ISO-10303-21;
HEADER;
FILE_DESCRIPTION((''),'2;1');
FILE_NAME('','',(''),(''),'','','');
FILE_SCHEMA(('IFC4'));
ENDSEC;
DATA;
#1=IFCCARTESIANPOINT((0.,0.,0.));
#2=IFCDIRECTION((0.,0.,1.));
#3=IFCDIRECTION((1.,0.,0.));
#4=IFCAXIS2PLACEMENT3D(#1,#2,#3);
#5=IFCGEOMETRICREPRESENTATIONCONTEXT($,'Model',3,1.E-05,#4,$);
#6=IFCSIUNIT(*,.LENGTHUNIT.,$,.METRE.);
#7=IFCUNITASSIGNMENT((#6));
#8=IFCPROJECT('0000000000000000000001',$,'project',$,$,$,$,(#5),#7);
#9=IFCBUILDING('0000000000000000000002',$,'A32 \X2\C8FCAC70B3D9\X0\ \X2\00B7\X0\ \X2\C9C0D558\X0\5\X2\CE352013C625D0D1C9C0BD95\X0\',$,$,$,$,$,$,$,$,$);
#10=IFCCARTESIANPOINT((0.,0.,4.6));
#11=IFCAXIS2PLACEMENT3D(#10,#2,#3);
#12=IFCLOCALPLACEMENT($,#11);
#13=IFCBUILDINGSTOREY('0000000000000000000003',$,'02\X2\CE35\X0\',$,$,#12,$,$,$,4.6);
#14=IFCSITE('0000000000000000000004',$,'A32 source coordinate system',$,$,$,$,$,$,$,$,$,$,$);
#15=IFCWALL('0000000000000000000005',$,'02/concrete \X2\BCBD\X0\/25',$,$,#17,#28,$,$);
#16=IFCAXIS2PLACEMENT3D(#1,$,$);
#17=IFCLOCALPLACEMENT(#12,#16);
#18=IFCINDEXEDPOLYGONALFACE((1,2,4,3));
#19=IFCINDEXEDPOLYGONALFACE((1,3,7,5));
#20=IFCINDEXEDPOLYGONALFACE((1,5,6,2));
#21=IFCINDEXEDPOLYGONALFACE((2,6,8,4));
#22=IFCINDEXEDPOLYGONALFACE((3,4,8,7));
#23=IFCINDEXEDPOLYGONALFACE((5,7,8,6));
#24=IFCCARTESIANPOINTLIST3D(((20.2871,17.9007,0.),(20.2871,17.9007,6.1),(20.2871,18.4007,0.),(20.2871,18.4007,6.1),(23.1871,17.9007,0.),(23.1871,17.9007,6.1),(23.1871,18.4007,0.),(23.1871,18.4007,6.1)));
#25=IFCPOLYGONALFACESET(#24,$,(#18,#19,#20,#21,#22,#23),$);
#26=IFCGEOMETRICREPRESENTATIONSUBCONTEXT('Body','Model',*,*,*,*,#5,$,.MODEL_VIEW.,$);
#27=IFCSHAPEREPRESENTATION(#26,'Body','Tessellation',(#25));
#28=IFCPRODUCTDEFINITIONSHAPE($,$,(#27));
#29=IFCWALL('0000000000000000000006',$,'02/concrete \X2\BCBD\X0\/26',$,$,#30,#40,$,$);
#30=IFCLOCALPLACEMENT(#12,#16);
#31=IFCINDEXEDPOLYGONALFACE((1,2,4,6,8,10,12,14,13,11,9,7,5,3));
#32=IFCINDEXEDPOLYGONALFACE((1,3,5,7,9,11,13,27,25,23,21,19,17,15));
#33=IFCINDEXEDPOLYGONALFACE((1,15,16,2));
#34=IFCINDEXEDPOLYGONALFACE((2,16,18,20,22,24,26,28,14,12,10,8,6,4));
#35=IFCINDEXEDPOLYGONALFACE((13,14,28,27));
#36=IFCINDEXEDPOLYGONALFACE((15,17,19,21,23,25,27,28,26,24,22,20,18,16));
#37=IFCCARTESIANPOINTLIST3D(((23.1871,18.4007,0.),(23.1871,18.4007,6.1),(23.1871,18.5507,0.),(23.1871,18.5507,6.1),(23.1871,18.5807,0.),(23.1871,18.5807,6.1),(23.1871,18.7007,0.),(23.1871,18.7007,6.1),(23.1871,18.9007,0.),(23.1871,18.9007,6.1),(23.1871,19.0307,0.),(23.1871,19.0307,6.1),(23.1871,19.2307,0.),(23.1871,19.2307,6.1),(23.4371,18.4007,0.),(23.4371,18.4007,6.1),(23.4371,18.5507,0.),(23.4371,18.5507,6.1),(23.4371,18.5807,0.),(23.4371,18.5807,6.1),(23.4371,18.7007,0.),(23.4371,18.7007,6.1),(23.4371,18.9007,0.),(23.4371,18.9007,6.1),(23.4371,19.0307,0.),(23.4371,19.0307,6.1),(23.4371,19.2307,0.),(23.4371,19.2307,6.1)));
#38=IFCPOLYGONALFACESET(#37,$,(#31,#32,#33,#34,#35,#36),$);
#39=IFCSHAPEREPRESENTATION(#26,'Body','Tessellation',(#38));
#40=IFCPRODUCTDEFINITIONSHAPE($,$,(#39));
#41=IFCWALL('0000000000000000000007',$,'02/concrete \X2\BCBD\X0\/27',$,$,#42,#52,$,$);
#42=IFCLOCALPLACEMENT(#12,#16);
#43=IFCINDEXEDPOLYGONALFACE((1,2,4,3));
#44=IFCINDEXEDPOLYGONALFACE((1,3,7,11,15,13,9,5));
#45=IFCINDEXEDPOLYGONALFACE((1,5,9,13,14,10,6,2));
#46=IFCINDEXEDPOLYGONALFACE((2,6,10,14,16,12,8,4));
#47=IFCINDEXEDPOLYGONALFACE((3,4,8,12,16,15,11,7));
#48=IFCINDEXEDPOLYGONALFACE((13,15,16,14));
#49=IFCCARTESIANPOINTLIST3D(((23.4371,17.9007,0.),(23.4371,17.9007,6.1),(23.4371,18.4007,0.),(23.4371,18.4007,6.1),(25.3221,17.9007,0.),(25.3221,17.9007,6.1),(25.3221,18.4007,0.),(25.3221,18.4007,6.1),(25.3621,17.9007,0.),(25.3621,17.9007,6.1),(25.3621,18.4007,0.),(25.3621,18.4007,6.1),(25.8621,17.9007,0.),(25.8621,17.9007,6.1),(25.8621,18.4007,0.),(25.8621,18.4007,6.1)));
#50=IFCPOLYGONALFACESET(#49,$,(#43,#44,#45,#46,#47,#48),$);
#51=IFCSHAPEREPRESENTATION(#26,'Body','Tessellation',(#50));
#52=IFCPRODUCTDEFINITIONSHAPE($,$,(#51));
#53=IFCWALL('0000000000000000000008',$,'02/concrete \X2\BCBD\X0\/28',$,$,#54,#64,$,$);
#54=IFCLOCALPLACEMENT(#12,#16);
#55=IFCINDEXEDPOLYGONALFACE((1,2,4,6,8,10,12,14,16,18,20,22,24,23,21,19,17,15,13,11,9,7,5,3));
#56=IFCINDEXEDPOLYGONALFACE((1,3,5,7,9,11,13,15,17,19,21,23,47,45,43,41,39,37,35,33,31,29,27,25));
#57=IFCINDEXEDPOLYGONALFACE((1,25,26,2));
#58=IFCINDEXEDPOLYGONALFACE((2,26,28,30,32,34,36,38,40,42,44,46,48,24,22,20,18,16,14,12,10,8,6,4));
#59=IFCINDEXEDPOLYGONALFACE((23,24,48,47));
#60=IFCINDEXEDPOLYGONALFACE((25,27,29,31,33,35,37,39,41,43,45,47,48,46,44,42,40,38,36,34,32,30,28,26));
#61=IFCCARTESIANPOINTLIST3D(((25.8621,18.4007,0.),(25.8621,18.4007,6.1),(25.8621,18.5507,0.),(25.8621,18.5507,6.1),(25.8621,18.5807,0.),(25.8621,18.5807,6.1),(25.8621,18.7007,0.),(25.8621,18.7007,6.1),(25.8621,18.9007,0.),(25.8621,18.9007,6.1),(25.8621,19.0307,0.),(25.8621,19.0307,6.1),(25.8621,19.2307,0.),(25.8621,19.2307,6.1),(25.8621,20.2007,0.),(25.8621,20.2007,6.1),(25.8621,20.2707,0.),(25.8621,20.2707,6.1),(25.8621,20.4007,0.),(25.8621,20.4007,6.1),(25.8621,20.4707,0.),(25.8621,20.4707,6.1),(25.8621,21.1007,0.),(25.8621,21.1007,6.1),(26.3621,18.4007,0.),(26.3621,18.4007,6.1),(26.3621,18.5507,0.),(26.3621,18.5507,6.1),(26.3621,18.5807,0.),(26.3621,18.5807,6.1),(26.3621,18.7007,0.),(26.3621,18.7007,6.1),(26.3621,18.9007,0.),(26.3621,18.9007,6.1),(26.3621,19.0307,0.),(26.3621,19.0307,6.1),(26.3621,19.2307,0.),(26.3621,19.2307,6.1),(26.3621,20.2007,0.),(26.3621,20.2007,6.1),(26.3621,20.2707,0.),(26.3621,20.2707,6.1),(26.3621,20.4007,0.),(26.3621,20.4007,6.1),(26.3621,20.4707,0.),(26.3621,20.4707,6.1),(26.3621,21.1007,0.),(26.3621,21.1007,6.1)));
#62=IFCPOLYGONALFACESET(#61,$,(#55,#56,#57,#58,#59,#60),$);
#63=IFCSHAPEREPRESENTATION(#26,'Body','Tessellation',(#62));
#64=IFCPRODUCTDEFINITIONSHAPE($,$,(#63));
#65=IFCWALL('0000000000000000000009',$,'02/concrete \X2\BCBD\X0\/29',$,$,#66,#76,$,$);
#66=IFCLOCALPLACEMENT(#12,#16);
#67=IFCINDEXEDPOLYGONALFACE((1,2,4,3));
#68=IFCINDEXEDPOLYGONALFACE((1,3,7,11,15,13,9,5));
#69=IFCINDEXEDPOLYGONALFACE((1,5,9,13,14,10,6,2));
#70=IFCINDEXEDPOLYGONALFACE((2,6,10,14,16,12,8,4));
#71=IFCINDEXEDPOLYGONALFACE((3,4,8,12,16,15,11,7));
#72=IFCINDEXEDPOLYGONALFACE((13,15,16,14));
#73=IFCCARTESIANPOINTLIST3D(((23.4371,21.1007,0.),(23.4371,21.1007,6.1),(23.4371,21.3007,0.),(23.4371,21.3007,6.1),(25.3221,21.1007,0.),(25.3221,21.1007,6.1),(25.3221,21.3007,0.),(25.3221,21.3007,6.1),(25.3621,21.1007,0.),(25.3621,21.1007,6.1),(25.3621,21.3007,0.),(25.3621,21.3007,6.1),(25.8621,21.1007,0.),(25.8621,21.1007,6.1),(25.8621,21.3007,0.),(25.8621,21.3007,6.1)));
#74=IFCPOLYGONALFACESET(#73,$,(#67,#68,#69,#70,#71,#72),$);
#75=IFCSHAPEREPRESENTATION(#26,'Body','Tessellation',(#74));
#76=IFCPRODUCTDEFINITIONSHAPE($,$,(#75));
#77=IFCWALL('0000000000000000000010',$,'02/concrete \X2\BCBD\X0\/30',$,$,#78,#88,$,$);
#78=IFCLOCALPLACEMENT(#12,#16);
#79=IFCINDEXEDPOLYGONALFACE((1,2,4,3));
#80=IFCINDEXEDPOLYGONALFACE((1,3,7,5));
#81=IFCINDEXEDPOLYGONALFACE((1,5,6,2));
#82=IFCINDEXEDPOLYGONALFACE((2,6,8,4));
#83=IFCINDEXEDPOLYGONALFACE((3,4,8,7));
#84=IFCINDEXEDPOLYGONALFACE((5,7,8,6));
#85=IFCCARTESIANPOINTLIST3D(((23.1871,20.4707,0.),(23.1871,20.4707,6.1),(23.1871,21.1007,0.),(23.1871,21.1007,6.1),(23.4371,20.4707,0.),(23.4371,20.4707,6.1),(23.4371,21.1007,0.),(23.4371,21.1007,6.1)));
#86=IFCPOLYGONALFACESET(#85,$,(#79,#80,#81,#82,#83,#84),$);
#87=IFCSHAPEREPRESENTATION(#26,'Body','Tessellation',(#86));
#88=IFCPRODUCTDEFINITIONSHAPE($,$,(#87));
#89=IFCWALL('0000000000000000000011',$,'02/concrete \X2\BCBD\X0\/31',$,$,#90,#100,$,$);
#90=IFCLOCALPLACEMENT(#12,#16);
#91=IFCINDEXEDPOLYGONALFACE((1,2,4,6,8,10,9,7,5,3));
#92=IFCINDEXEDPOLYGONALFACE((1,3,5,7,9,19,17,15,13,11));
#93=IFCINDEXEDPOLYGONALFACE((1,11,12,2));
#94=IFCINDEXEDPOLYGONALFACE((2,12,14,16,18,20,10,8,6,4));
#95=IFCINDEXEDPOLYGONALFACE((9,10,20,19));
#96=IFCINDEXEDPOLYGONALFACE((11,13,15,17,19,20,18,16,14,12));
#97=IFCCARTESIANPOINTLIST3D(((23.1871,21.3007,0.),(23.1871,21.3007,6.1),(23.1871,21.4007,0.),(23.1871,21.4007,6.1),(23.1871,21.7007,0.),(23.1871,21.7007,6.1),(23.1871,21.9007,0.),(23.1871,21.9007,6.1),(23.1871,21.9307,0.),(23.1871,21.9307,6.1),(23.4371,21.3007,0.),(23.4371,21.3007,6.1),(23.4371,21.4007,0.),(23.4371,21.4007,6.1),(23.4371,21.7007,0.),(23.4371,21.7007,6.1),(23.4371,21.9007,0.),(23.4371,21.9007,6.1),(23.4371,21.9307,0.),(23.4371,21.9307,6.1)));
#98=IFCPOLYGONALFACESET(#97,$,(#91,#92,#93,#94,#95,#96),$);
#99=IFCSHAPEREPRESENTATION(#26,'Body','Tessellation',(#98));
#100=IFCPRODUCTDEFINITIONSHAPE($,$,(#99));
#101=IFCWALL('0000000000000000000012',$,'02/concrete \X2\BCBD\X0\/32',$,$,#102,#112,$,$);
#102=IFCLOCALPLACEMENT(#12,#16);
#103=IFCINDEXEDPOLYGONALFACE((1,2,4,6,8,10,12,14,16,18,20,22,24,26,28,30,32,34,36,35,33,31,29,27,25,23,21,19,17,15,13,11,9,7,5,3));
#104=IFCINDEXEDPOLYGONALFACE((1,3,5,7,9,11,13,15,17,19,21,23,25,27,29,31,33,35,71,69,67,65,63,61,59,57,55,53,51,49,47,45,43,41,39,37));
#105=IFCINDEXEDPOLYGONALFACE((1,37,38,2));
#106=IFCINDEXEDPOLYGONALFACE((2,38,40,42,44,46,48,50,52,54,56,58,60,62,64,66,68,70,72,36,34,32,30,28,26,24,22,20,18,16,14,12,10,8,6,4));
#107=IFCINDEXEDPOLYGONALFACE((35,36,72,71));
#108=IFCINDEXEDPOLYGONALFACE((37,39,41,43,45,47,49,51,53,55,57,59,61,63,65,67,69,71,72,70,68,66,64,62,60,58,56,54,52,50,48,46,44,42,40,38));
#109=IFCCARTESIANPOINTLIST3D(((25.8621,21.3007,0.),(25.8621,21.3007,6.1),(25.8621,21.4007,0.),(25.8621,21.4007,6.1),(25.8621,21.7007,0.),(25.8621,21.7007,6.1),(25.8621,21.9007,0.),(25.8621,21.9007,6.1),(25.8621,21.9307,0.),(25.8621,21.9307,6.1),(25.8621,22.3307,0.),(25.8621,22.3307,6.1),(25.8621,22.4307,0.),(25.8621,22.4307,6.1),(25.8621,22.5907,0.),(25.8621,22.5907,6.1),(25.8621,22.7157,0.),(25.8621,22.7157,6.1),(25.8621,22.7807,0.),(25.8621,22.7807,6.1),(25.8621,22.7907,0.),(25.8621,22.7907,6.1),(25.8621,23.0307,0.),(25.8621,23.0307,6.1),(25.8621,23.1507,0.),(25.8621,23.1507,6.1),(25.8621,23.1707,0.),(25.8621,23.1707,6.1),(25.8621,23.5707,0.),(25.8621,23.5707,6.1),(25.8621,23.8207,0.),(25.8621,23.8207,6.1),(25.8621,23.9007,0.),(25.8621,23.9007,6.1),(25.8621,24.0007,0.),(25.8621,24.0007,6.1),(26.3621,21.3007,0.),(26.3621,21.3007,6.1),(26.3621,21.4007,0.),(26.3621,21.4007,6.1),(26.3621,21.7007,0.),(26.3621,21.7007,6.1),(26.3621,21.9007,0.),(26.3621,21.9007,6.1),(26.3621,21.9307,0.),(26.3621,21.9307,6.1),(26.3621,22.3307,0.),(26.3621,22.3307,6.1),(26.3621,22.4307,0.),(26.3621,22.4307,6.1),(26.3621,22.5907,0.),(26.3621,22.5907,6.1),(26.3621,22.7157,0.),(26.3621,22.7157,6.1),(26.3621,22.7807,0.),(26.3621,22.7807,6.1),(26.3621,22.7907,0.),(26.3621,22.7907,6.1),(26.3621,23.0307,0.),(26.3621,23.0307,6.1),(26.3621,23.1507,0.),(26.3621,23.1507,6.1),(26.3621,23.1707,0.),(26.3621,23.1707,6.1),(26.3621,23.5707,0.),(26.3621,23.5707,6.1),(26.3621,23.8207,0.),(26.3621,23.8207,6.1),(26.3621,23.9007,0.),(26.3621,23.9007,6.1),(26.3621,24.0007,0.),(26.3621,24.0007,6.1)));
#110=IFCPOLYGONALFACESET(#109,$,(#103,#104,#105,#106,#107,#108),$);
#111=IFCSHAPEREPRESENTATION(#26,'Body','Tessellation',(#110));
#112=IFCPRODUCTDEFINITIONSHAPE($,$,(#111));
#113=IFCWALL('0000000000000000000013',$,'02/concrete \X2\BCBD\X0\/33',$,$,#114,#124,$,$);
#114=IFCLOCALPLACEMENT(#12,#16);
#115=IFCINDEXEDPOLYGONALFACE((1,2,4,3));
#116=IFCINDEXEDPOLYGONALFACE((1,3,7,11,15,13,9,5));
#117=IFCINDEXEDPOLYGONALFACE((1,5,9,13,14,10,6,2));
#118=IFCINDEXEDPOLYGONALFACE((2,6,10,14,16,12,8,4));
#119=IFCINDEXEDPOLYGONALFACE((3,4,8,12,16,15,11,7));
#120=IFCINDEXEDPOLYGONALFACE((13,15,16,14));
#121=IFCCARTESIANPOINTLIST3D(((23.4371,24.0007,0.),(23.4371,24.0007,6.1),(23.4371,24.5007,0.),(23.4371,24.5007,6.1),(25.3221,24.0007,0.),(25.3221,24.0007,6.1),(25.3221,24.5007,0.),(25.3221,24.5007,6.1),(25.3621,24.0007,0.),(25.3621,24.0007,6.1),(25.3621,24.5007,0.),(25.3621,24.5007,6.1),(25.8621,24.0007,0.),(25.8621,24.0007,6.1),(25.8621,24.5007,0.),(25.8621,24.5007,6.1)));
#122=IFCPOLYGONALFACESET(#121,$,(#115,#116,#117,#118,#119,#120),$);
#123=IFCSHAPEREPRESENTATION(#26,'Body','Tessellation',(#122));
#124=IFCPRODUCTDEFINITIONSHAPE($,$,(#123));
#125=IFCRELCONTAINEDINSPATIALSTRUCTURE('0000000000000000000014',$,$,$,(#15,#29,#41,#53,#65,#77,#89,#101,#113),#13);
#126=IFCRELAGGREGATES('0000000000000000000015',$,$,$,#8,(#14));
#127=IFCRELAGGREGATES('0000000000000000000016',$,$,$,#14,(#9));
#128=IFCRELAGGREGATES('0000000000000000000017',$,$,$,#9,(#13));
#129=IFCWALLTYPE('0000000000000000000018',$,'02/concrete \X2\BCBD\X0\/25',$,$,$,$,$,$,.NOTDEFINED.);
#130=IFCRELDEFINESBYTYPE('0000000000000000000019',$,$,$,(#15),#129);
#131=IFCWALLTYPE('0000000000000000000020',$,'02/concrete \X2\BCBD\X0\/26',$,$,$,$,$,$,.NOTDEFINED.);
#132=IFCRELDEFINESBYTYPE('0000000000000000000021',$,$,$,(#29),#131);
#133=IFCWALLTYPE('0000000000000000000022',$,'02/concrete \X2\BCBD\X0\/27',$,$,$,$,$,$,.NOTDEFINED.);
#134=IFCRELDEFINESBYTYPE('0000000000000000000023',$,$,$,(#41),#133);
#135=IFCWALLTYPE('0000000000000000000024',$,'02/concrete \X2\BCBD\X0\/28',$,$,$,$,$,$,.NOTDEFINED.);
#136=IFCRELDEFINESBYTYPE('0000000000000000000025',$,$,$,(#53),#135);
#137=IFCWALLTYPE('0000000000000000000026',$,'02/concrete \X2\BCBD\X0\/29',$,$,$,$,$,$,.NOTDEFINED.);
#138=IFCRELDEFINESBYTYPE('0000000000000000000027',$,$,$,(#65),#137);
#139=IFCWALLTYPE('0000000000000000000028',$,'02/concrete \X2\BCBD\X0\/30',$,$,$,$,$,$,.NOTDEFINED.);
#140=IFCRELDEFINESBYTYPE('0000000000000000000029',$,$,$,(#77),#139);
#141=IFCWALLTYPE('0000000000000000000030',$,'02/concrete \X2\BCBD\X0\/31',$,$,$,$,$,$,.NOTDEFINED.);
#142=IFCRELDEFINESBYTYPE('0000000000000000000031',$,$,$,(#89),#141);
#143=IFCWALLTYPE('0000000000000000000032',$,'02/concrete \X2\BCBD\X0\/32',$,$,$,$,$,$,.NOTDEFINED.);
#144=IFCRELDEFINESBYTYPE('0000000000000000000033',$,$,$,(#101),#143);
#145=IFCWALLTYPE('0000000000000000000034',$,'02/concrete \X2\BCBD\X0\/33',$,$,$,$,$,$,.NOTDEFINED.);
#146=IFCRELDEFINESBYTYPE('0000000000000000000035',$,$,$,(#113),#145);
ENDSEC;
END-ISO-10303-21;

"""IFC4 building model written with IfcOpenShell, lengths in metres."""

from ifc_helpers import new_model, si_unit, frame, origin, origin_with_axes, place, context, subcontext, project, spatial, polyline, outline, extrude, source, transform, mapped, type_object, type_shapes, element, save


model = new_model("IFC4")

# Units and contexts
model_context = context("Model", 3, precision=1e-05, world=origin_with_axes())
body_context = subcontext(model_context, "Body", "Model", "MODEL_VIEW")
ifc_project = project(units=[si_unit("LENGTHUNIT", "METRE")], contexts=[model_context])

# Site, building, storey
site = spatial("IfcSite", under=ifc_project, Name="A32 source coordinate system")
building = spatial("IfcBuilding", under=site, Name="A32 주거동 · 지하5층–옥탑지붕")
storey_placement = place(None, frame((0.0, 0.0, 4.6), z_axis=(0.0, 0.0, 1.0), x_axis=(1.0, 0.0, 0.0)))
storey = spatial("IfcBuildingStorey", under=building, at=storey_placement, Name="02층", Elevation=4.6)

# Walls
wall_type_1 = type_object("IfcWallType", Name="02/concrete 벽/25", PredefinedType="NOTDEFINED")
shared_shape_1 = source(origin(), body_context, "Body", "SweptSolid", [
    extrude(outline(polyline([(20.2871, 17.9007), (20.2871, 18.4007), (23.1871, 18.4007), (23.1871, 17.9007), (20.2871, 17.9007)])), origin(), (0.0, 0.0, 1.0), 6.1),
])
type_shapes(wall_type_1, [shared_shape_1])
wall_1_placement = place(storey_placement, origin_with_axes())
element("IfcWall", 1, at=wall_1_placement, inside=storey, type_object=wall_type_1, Name="02/concrete 벽/25", context=body_context, shape_type="MappedRepresentation", body=[
    mapped(shared_shape_1, transform((0.0, 0.0, 0.0), scale=1.0)),
])
wall_type_2 = type_object("IfcWallType", Name="02/concrete 벽/26", PredefinedType="NOTDEFINED")
shared_shape_2 = source(origin(), body_context, "Body", "SweptSolid", [
    extrude(outline(polyline([(23.1871, 18.7007), (23.1871, 18.9007), (23.1871, 19.0307), (23.1871, 19.2307), (23.4371, 19.2307), (23.4371, 19.0307), (23.4371, 18.9007), (23.4371, 18.7007), (23.4371, 18.5807), (23.4371, 18.5507), (23.4371, 18.4007), (23.1871, 18.4007), (23.1871, 18.5507), (23.1871, 18.5807), (23.1871, 18.7007)])), origin(), (0.0, 0.0, 1.0), 6.1),
])
type_shapes(wall_type_2, [shared_shape_2])
wall_2_placement = place(storey_placement, origin_with_axes())
element("IfcWall", 2, at=wall_2_placement, inside=storey, type_object=wall_type_2, Name="02/concrete 벽/26", context=body_context, shape_type="MappedRepresentation", body=[
    mapped(shared_shape_2, transform((0.0, 0.0, 0.0), scale=1.0)),
])
wall_type_3 = type_object("IfcWallType", Name="02/concrete 벽/27", PredefinedType="NOTDEFINED")
shared_shape_3 = source(origin(), body_context, "Body", "SweptSolid", [
    extrude(outline(polyline([(25.8621, 18.4007), (25.8621, 17.9007), (25.3621, 17.9007), (25.3221, 17.9007), (23.4371, 17.9007), (23.4371, 18.4007), (25.3221, 18.4007), (25.3621, 18.4007), (25.8621, 18.4007)])), origin(), (0.0, 0.0, 1.0), 6.1),
])
type_shapes(wall_type_3, [shared_shape_3])
wall_3_placement = place(storey_placement, origin_with_axes())
element("IfcWall", 3, at=wall_3_placement, inside=storey, type_object=wall_type_3, Name="02/concrete 벽/27", context=body_context, shape_type="MappedRepresentation", body=[
    mapped(shared_shape_3, transform((0.0, 0.0, 0.0), scale=1.0)),
])
wall_type_4 = type_object("IfcWallType", Name="02/concrete 벽/28", PredefinedType="NOTDEFINED")
shared_shape_4 = source(origin(), body_context, "Body", "SweptSolid", [
    extrude(outline(polyline([(25.8621, 18.7007), (25.8621, 18.9007), (25.8621, 19.0307), (25.8621, 19.2307), (25.8621, 20.2007), (25.8621, 20.2707), (25.8621, 20.4007), (25.8621, 20.4707), (25.8621, 21.1007), (26.3621, 21.1007), (26.3621, 20.4707), (26.3621, 20.4007), (26.3621, 20.2707), (26.3621, 20.2007), (26.3621, 19.2307), (26.3621, 19.0307), (26.3621, 18.9007), (26.3621, 18.7007), (26.3621, 18.5807), (26.3621, 18.5507), (26.3621, 18.4007), (25.8621, 18.4007), (25.8621, 18.5507), (25.8621, 18.5807), (25.8621, 18.7007)])), origin(), (0.0, 0.0, 1.0), 6.1),
])
type_shapes(wall_type_4, [shared_shape_4])
wall_4_placement = place(storey_placement, origin_with_axes())
element("IfcWall", 4, at=wall_4_placement, inside=storey, type_object=wall_type_4, Name="02/concrete 벽/28", context=body_context, shape_type="MappedRepresentation", body=[
    mapped(shared_shape_4, transform((0.0, 0.0, 0.0), scale=1.0)),
])
wall_type_5 = type_object("IfcWallType", Name="02/concrete 벽/29", PredefinedType="NOTDEFINED")
shared_shape_5 = source(origin(), body_context, "Body", "SweptSolid", [
    extrude(outline(polyline([(23.4371, 21.1007), (23.4371, 21.3007), (25.3221, 21.3007), (25.3621, 21.3007), (25.8621, 21.3007), (25.8621, 21.1007), (25.3621, 21.1007), (25.3221, 21.1007), (23.4371, 21.1007)])), origin(), (0.0, 0.0, 1.0), 6.1),
])
type_shapes(wall_type_5, [shared_shape_5])
wall_5_placement = place(storey_placement, origin_with_axes())
element("IfcWall", 5, at=wall_5_placement, inside=storey, type_object=wall_type_5, Name="02/concrete 벽/29", context=body_context, shape_type="MappedRepresentation", body=[
    mapped(shared_shape_5, transform((0.0, 0.0, 0.0), scale=1.0)),
])
wall_type_6 = type_object("IfcWallType", Name="02/concrete 벽/30", PredefinedType="NOTDEFINED")
shared_shape_6 = source(origin(), body_context, "Body", "SweptSolid", [
    extrude(outline(polyline([(23.1871, 21.1007), (23.4371, 21.1007), (23.4371, 20.4707), (23.1871, 20.4707), (23.1871, 21.1007)])), origin(), (0.0, 0.0, 1.0), 6.1),
])
type_shapes(wall_type_6, [shared_shape_6])
wall_6_placement = place(storey_placement, origin_with_axes())
element("IfcWall", 6, at=wall_6_placement, inside=storey, type_object=wall_type_6, Name="02/concrete 벽/30", context=body_context, shape_type="MappedRepresentation", body=[
    mapped(shared_shape_6, transform((0.0, 0.0, 0.0), scale=1.0)),
])
wall_type_7 = type_object("IfcWallType", Name="02/concrete 벽/31", PredefinedType="NOTDEFINED")
shared_shape_7 = source(origin(), body_context, "Body", "SweptSolid", [
    extrude(outline(polyline([(23.1871, 21.7007), (23.1871, 21.9007), (23.1871, 21.9307), (23.4371, 21.9307), (23.4371, 21.9007), (23.4371, 21.7007), (23.4371, 21.4007), (23.4371, 21.3007), (23.1871, 21.3007), (23.1871, 21.4007), (23.1871, 21.7007)])), origin(), (0.0, 0.0, 1.0), 6.1),
])
type_shapes(wall_type_7, [shared_shape_7])
wall_7_placement = place(storey_placement, origin_with_axes())
element("IfcWall", 7, at=wall_7_placement, inside=storey, type_object=wall_type_7, Name="02/concrete 벽/31", context=body_context, shape_type="MappedRepresentation", body=[
    mapped(shared_shape_7, transform((0.0, 0.0, 0.0), scale=1.0)),
])
wall_type_8 = type_object("IfcWallType", Name="02/concrete 벽/32", PredefinedType="NOTDEFINED")
shared_shape_8 = source(origin(), body_context, "Body", "SweptSolid", [
    extrude(outline(polyline([(25.8621, 21.9007), (25.8621, 21.9307), (25.8621, 22.3307), (25.8621, 22.4307), (25.8621, 22.5907), (25.8621, 22.7157), (25.8621, 22.7807), (25.8621, 22.7907), (25.8621, 23.0307), (25.8621, 23.1507), (25.8621, 23.1707), (25.8621, 23.5707), (25.8621, 23.8207), (25.8621, 23.9007), (25.8621, 24.0007), (26.3621, 24.0007), (26.3621, 23.9007), (26.3621, 23.8207), (26.3621, 23.5707), (26.3621, 23.1707), (26.3621, 23.1507), (26.3621, 23.0307), (26.3621, 22.7907), (26.3621, 22.7807), (26.3621, 22.7157), (26.3621, 22.5907), (26.3621, 22.4307), (26.3621, 22.3307), (26.3621, 21.9307), (26.3621, 21.9007), (26.3621, 21.7007), (26.3621, 21.4007), (26.3621, 21.3007), (25.8621, 21.3007), (25.8621, 21.4007), (25.8621, 21.7007), (25.8621, 21.9007)])), origin(), (0.0, 0.0, 1.0), 6.1),
])
type_shapes(wall_type_8, [shared_shape_8])
wall_8_placement = place(storey_placement, origin_with_axes())
element("IfcWall", 8, at=wall_8_placement, inside=storey, type_object=wall_type_8, Name="02/concrete 벽/32", context=body_context, shape_type="MappedRepresentation", body=[
    mapped(shared_shape_8, transform((0.0, 0.0, 0.0), scale=1.0)),
])
wall_type_9 = type_object("IfcWallType", Name="02/concrete 벽/33", PredefinedType="NOTDEFINED")
shared_shape_9 = source(origin(), body_context, "Body", "SweptSolid", [
    extrude(outline(polyline([(23.4371, 24.0007), (23.4371, 24.5007), (25.3221, 24.5007), (25.3621, 24.5007), (25.8621, 24.5007), (25.8621, 24.0007), (25.3621, 24.0007), (25.3221, 24.0007), (23.4371, 24.0007)])), origin(), (0.0, 0.0, 1.0), 6.1),
])
type_shapes(wall_type_9, [shared_shape_9])
wall_9_placement = place(storey_placement, origin_with_axes())
element("IfcWall", 9, at=wall_9_placement, inside=storey, type_object=wall_type_9, Name="02/concrete 벽/33", context=body_context, shape_type="MappedRepresentation", body=[
    mapped(shared_shape_9, transform((0.0, 0.0, 0.0), scale=1.0)),
])

save(model, "model.ifc")
